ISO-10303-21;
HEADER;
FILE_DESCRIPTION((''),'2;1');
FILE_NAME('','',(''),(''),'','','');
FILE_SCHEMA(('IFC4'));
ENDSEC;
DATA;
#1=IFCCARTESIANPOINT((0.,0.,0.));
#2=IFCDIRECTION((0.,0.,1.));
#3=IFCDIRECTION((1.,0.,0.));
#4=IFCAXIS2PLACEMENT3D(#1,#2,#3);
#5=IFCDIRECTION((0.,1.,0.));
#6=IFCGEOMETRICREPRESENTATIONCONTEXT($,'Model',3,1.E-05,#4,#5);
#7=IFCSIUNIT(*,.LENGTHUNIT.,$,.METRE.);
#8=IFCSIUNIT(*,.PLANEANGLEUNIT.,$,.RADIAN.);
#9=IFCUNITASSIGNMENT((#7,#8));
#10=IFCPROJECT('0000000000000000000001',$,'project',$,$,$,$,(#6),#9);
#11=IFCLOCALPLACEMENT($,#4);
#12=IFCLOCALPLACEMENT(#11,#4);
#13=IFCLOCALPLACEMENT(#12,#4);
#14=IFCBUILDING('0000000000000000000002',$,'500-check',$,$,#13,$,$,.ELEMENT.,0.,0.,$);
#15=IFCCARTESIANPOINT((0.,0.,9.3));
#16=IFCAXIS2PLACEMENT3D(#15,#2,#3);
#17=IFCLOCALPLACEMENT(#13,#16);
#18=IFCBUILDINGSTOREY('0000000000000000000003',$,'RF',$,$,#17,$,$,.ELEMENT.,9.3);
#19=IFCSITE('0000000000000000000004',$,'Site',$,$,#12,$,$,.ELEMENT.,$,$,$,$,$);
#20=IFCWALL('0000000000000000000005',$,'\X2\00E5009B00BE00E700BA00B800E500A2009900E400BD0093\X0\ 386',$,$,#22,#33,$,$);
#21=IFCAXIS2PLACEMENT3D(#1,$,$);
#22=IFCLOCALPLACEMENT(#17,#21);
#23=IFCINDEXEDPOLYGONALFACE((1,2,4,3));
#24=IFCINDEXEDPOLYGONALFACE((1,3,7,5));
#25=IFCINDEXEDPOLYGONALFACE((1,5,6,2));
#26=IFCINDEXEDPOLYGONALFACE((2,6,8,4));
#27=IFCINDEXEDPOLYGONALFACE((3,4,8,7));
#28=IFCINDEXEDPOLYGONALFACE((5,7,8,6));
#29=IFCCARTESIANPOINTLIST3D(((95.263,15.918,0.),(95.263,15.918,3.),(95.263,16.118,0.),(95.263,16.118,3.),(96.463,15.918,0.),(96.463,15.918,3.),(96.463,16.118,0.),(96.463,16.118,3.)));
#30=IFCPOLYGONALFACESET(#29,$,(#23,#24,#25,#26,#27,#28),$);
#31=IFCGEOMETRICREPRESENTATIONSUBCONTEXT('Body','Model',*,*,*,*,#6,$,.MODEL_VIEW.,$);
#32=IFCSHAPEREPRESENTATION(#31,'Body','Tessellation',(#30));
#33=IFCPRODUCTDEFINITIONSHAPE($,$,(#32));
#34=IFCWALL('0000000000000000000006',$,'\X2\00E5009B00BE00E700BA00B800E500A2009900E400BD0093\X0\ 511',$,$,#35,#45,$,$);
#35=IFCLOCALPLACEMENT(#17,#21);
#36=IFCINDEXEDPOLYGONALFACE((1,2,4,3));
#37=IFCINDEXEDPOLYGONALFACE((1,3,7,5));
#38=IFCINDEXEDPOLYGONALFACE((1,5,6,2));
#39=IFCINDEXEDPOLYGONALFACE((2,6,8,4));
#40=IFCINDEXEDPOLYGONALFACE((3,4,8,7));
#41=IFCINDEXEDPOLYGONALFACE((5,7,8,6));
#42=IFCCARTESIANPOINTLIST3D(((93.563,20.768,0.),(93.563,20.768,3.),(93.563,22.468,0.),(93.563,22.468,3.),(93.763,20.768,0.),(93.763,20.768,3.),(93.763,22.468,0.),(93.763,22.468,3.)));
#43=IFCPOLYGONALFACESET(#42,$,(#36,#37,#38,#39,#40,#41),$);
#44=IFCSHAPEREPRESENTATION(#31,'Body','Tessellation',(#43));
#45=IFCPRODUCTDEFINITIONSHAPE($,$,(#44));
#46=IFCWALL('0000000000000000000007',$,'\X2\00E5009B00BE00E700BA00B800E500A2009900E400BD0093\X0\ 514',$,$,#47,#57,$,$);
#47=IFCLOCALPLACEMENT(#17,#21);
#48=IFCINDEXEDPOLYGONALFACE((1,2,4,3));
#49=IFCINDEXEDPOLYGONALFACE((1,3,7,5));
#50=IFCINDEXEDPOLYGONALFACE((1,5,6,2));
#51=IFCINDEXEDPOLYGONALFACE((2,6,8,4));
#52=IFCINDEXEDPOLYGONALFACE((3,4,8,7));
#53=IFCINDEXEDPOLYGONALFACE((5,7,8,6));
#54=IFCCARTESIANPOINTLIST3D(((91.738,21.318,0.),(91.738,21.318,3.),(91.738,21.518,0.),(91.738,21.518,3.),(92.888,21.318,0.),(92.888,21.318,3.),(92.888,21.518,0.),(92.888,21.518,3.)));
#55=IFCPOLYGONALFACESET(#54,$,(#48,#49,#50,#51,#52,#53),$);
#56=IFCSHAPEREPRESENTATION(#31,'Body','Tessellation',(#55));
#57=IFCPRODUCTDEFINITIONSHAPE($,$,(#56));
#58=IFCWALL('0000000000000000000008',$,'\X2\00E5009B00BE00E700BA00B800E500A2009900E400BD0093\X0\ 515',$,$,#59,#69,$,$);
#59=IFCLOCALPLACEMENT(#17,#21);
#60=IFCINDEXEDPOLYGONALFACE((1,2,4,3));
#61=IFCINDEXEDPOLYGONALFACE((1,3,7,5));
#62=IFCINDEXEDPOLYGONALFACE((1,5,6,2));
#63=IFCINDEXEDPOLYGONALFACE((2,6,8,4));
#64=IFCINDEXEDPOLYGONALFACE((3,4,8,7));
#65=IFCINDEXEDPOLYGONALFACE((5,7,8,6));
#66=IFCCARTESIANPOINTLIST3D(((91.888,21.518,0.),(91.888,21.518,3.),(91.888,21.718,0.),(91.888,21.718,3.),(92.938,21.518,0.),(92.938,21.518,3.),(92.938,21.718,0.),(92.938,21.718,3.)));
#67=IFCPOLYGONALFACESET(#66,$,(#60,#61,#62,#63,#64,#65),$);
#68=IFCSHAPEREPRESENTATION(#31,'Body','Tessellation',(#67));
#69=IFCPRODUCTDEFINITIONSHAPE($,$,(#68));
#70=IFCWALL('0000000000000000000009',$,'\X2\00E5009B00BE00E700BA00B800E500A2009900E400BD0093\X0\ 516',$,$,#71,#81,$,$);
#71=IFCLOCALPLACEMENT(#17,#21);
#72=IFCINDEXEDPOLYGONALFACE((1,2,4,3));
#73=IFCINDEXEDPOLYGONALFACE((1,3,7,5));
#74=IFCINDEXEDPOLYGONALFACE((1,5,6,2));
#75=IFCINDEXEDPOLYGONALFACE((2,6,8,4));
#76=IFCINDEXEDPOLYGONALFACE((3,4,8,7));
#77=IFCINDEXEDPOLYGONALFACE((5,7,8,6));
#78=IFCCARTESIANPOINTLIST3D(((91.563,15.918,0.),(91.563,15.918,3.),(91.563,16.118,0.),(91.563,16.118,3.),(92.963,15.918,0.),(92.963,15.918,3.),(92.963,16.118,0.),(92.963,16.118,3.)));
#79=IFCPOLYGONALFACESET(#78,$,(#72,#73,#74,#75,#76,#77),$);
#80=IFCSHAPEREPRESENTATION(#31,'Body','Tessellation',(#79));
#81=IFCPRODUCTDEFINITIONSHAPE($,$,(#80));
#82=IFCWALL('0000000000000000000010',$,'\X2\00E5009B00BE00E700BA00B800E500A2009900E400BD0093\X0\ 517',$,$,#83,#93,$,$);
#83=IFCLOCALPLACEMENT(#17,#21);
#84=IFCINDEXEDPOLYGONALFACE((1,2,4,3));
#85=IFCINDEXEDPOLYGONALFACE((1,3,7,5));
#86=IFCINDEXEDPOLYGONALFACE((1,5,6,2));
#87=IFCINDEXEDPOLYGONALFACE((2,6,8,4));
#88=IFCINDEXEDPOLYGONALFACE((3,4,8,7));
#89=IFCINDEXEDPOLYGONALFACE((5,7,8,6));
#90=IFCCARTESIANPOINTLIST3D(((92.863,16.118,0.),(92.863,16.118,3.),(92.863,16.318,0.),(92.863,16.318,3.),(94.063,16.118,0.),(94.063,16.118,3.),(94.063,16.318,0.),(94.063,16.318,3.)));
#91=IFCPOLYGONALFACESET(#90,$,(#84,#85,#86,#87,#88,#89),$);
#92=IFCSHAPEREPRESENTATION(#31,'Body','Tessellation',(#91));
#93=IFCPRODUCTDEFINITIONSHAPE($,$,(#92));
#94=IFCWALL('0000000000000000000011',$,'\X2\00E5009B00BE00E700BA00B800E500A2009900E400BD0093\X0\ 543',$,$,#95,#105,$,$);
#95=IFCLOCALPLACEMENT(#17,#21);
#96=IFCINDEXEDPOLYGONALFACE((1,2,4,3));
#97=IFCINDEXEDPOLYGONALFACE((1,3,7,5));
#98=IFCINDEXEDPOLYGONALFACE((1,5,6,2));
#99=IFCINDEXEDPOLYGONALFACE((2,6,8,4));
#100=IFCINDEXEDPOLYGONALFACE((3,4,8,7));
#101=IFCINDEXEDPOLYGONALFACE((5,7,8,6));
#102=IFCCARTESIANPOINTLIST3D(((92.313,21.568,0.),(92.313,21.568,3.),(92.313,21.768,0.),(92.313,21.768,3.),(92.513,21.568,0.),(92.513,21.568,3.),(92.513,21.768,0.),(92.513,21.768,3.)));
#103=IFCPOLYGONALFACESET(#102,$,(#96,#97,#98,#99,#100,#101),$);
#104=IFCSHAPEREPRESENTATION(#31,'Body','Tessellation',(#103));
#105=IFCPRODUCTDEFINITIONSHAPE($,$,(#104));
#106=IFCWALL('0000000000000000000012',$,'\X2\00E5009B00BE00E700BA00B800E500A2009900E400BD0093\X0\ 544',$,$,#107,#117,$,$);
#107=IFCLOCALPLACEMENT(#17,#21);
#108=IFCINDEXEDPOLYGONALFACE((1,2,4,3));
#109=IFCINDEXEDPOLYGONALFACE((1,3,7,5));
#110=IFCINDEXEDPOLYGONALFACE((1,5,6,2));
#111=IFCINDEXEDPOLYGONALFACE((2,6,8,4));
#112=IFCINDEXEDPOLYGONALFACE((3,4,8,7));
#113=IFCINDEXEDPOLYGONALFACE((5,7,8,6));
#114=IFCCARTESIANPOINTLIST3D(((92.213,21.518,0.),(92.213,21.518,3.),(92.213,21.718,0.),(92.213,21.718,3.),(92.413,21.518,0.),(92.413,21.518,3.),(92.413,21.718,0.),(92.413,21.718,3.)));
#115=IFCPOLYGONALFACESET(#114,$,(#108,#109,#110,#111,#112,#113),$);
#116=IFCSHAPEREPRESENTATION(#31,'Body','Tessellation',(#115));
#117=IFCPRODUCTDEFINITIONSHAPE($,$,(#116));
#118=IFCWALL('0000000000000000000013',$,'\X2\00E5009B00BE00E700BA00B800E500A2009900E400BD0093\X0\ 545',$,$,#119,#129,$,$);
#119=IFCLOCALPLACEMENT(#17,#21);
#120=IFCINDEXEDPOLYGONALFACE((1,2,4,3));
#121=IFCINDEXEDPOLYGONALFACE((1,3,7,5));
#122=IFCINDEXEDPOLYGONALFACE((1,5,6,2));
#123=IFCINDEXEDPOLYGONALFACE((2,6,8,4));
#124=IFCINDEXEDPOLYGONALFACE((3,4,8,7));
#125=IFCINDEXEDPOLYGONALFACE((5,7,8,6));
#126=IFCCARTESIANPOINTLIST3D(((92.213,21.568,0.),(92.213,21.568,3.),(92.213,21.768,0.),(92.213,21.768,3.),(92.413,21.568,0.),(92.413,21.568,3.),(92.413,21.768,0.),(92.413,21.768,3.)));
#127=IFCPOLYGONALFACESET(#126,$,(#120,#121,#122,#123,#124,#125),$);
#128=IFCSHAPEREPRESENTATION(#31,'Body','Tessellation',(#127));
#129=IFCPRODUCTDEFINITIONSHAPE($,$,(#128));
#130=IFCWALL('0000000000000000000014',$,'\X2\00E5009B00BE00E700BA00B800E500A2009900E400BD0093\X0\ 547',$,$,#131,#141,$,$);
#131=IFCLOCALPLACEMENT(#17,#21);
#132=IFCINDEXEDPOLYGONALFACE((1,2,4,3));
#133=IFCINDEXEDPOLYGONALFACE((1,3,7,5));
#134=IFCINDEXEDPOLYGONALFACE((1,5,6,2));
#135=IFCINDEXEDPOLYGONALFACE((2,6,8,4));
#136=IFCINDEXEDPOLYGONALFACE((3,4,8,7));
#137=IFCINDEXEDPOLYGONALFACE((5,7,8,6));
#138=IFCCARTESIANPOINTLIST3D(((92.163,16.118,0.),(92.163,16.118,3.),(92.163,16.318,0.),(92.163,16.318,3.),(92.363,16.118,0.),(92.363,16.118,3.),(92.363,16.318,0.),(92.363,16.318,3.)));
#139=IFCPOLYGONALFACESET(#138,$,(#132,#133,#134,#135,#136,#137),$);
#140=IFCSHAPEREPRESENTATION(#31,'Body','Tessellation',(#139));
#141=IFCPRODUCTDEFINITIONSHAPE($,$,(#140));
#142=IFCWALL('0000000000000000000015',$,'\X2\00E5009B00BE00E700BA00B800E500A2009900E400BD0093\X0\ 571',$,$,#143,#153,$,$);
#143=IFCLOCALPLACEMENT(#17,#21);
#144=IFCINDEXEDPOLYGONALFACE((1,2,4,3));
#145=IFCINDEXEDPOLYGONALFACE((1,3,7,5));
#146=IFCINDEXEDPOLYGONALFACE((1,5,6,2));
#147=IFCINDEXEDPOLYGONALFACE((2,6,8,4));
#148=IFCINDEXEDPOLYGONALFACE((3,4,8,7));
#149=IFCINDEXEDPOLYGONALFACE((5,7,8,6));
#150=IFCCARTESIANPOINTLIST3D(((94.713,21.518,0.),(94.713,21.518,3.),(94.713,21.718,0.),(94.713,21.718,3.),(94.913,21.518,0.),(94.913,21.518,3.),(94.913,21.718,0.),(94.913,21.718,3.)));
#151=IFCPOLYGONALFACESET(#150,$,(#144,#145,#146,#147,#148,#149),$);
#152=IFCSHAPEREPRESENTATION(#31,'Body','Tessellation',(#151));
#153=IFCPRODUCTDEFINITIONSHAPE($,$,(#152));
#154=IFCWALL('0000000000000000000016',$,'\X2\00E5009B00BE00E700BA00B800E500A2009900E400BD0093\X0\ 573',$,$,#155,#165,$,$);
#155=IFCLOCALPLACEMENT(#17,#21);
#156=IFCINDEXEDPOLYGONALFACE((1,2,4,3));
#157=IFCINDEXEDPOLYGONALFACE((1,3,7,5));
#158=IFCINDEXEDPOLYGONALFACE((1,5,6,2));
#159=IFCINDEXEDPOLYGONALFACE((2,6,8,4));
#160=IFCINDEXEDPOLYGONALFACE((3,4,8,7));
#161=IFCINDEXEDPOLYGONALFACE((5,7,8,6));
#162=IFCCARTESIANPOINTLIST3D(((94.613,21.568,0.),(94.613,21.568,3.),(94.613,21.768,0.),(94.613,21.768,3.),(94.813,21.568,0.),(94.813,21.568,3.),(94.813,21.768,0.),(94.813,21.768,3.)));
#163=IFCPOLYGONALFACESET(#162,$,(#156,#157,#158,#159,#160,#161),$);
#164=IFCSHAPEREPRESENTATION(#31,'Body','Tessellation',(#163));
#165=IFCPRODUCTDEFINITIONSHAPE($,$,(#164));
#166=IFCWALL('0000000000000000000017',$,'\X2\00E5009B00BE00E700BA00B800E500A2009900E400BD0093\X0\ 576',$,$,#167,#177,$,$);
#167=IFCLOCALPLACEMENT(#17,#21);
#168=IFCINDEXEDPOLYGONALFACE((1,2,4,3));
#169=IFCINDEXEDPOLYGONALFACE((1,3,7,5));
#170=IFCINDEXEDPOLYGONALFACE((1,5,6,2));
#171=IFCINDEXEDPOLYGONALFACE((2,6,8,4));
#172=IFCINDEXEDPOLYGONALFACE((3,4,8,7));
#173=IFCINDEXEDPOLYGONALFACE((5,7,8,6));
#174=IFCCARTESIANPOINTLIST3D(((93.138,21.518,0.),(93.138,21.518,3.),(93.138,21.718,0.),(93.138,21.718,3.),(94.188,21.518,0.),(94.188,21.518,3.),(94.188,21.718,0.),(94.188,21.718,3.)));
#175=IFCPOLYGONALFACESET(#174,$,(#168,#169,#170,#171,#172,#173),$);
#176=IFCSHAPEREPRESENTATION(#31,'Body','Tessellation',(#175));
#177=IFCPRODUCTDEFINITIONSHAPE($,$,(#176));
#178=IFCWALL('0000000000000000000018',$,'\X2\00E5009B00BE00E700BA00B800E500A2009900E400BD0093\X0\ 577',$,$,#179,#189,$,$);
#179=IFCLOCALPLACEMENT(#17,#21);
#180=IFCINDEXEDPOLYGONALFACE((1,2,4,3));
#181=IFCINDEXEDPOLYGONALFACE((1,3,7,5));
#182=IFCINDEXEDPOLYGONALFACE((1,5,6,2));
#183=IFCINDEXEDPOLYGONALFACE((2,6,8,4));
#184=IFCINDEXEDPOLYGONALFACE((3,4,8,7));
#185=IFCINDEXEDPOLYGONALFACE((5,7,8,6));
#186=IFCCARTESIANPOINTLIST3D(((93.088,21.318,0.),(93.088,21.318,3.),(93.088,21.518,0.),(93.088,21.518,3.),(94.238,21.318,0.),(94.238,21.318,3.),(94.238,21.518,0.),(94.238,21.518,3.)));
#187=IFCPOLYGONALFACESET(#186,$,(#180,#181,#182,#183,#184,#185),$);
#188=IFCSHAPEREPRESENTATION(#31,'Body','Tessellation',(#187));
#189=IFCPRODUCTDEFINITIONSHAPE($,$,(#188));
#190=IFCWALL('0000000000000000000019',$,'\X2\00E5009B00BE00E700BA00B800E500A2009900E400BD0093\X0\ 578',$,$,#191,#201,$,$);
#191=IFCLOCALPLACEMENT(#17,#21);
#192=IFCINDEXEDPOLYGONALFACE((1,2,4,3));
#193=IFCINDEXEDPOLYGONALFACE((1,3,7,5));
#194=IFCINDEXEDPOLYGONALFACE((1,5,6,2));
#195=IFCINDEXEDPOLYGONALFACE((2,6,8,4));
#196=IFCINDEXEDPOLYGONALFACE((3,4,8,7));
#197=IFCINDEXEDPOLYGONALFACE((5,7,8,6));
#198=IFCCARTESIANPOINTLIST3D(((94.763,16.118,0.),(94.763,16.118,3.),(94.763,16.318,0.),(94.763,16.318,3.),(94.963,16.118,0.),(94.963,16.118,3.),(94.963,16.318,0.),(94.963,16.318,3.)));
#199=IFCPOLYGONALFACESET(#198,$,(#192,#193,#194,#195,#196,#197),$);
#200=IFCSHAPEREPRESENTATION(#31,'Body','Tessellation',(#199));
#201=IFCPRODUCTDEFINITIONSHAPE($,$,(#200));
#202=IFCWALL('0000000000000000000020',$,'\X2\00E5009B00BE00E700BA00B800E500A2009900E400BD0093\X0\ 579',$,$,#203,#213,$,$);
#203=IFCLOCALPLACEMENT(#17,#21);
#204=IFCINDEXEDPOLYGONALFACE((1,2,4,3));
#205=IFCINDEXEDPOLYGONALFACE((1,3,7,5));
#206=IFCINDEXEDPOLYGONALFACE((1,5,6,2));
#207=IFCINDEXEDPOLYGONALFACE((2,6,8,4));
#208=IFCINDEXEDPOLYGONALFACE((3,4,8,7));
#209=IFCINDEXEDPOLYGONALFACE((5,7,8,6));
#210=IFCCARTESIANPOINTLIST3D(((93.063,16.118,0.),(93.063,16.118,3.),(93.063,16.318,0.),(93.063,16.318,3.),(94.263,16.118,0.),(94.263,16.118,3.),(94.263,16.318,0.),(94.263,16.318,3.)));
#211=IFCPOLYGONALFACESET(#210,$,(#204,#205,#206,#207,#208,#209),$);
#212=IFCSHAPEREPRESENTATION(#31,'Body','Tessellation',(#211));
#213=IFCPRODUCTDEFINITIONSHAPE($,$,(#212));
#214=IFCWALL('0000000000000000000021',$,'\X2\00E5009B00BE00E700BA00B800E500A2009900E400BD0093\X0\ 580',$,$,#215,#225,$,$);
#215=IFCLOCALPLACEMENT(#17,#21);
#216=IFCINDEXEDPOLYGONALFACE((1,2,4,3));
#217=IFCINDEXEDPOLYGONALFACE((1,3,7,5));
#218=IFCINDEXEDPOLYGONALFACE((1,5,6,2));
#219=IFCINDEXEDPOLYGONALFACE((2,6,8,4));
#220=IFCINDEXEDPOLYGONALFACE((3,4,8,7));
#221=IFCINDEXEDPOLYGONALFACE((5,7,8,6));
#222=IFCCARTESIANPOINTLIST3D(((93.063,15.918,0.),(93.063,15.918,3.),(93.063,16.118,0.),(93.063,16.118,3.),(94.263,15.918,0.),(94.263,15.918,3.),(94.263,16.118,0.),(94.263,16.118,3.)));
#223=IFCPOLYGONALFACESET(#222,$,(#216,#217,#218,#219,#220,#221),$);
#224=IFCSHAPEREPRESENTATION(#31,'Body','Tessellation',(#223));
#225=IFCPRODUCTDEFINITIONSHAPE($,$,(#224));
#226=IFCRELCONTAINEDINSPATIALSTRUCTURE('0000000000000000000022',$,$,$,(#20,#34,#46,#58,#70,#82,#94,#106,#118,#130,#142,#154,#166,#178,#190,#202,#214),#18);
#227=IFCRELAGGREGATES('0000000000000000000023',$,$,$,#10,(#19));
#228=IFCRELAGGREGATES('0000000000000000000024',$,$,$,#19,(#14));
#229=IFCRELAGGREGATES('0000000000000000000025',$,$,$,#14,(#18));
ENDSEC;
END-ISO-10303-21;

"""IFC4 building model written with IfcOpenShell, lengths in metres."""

from ifc_helpers import new_model, si_unit, direction, frame, frame_2d, origin_with_axes, place, context, subcontext, project, spatial, rectangle, extrude, element, save


model = new_model("IFC4")

# Units and contexts
model_context = context("Model", 3, precision=1e-05, world=origin_with_axes(), true_north=direction((0.0, 1.0, 0.0)))
body_context = subcontext(model_context, "Body", "Model", "MODEL_VIEW")
ifc_project = project(units=[si_unit("LENGTHUNIT", "METRE"), si_unit("PLANEANGLEUNIT", "RADIAN")], contexts=[model_context])

# Site, building, storey
placement = place(None, origin_with_axes())
site_placement = place(placement, origin_with_axes())
site = spatial("IfcSite", under=ifc_project, at=site_placement, Name="Site", CompositionType="ELEMENT")
building_placement = place(site_placement, origin_with_axes())
building = spatial("IfcBuilding", under=site, at=building_placement, Name="500-check", CompositionType="ELEMENT", ElevationOfRefHeight=0.0, ElevationOfTerrain=0.0)
storey_placement = place(building_placement, frame((0.0, 0.0, 9.3), z_axis=(0.0, 0.0, 1.0), x_axis=(1.0, 0.0, 0.0)))
storey = spatial("IfcBuildingStorey", under=building, at=storey_placement, Name="RF", CompositionType="ELEMENT", Elevation=9.3)

# Walls
wall_1_placement = place(storey_placement, frame((95.863, 16.018, 0.0), z_axis=(0.0, 0.0, 1.0), x_axis=(1.0, 0.0, 0.0)))
element("IfcWall", 1, at=wall_1_placement, inside=storey, Name="å\u009b¾çº¸å¢\u0099ä½\u0093 386", context=body_context, shape_type="SweptSolid", body=[
    extrude(rectangle(XDim=1.2, YDim=0.2, at=frame_2d((0.0, 0.0), x_axis=(1.0, 0.0, 0.0))), frame((0.0, 0.0, 0.0), z_axis=(0.0, 0.0, 1.0)), (0.0, 0.0, 1.0), 3.0),
])
wall_2_placement = place(storey_placement, frame((93.663, 21.618, 0.0), z_axis=(0.0, 0.0, 1.0), x_axis=(0.0, 1.0, 0.0)))
element("IfcWall", 2, at=wall_2_placement, inside=storey, Name="å\u009b¾çº¸å¢\u0099ä½\u0093 511", context=body_context, shape_type="SweptSolid", body=[
    extrude(rectangle(XDim=1.7, YDim=0.2, at=frame_2d((0.0, 0.0), x_axis=(1.0, 0.0, 0.0))), frame((0.0, 0.0, 0.0), z_axis=(0.0, 0.0, 1.0)), (0.0, 0.0, 1.0), 3.0),
])
wall_3_placement = place(storey_placement, frame((92.313, 21.418, 0.0), z_axis=(0.0, 0.0, 1.0), x_axis=(1.0, 0.0, 0.0)))
element("IfcWall", 3, at=wall_3_placement, inside=storey, Name="å\u009b¾çº¸å¢\u0099ä½\u0093 514", context=body_context, shape_type="SweptSolid", body=[
    extrude(rectangle(XDim=1.15, YDim=0.2, at=frame_2d((0.0, 0.0), x_axis=(1.0, 0.0, 0.0))), frame((0.0, 0.0, 0.0), z_axis=(0.0, 0.0, 1.0)), (0.0, 0.0, 1.0), 3.0),
])
wall_4_placement = place(storey_placement, frame((92.413, 21.618, 0.0), z_axis=(0.0, 0.0, 1.0), x_axis=(1.0, 0.0, 0.0)))
element("IfcWall", 4, at=wall_4_placement, inside=storey, Name="å\u009b¾çº¸å¢\u0099ä½\u0093 515", context=body_context, shape_type="SweptSolid", body=[
    extrude(rectangle(XDim=1.05, YDim=0.2, at=frame_2d((0.0, 0.0), x_axis=(1.0, 0.0, 0.0))), frame((0.0, 0.0, 0.0), z_axis=(0.0, 0.0, 1.0)), (0.0, 0.0, 1.0), 3.0),
])
wall_5_placement = place(storey_placement, frame((92.263, 16.018, 0.0), z_axis=(0.0, 0.0, 1.0), x_axis=(1.0, 0.0, 0.0)))
element("IfcWall", 5, at=wall_5_placement, inside=storey, Name="å\u009b¾çº¸å¢\u0099ä½\u0093 516", context=body_context, shape_type="SweptSolid", body=[
    extrude(rectangle(XDim=1.4, YDim=0.2, at=frame_2d((0.0, 0.0), x_axis=(1.0, 0.0, 0.0))), frame((0.0, 0.0, 0.0), z_axis=(0.0, 0.0, 1.0)), (0.0, 0.0, 1.0), 3.0),
])
wall_6_placement = place(storey_placement, frame((93.463, 16.218, 0.0), z_axis=(0.0, 0.0, 1.0), x_axis=(-1.0, 0.0, 0.0)))
element("IfcWall", 6, at=wall_6_placement, inside=storey, Name="å\u009b¾çº¸å¢\u0099ä½\u0093 517", context=body_context, shape_type="SweptSolid", body=[
    extrude(rectangle(XDim=1.2, YDim=0.2, at=frame_2d((0.0, 0.0), x_axis=(1.0, 0.0, 0.0))), frame((0.0, 0.0, 0.0), z_axis=(0.0, 0.0, 1.0)), (0.0, 0.0, 1.0), 3.0),
])
for number, where, z_axis, x_axis, name in (
    (7, (92.413, 21.668, 0.0), (0.0, 0.0, 1.0), (-1.0, 0.0, 0.0), "å\u009b¾çº¸å¢\u0099ä½\u0093 543"),
    (8, (92.313, 21.618, 0.0), (0.0, 0.0, 1.0), (0.0, -1.0, 0.0), "å\u009b¾çº¸å¢\u0099ä½\u0093 544"),
    (9, (92.313, 21.668, 0.0), (0.0, 0.0, 1.0), (0.0, -1.0, 0.0), "å\u009b¾çº¸å¢\u0099ä½\u0093 545"),
    (10, (92.263, 16.218, 0.0), (0.0, 0.0, 1.0), (0.0, -1.0, 0.0), "å\u009b¾çº¸å¢\u0099ä½\u0093 547"),
    (11, (94.813, 21.618, 0.0), (0.0, 0.0, 1.0), (0.0, -1.0, 0.0), "å\u009b¾çº¸å¢\u0099ä½\u0093 571"),
    (12, (94.713, 21.668, 0.0), (0.0, 0.0, 1.0), (1.0, 0.0, 0.0), "å\u009b¾çº¸å¢\u0099ä½\u0093 573"),
):
    element("IfcWall", number, at=place(storey_placement, frame(where, z_axis=z_axis, x_axis=x_axis)), inside=storey, Name=name, context=body_context, shape_type="SweptSolid", body=[
        extrude(rectangle(XDim=0.2, YDim=0.2, at=frame_2d((0.0, 0.0), x_axis=(1.0, 0.0, 0.0))), frame((0.0, 0.0, 0.0), z_axis=(0.0, 0.0, 1.0)), (0.0, 0.0, 1.0), 3.0),
    ])
wall_7_placement = place(storey_placement, frame((93.663, 21.618, 0.0), z_axis=(0.0, 0.0, 1.0), x_axis=(1.0, 0.0, 0.0)))
element("IfcWall", 13, at=wall_7_placement, inside=storey, Name="å\u009b¾çº¸å¢\u0099ä½\u0093 576", context=body_context, shape_type="SweptSolid", body=[
    extrude(rectangle(XDim=1.05, YDim=0.2, at=frame_2d((0.0, 0.0), x_axis=(1.0, 0.0, 0.0))), frame((0.0, 0.0, 0.0), z_axis=(0.0, 0.0, 1.0)), (0.0, 0.0, 1.0), 3.0),
])
wall_8_placement = place(storey_placement, frame((93.663, 21.418, 0.0), z_axis=(0.0, 0.0, 1.0), x_axis=(1.0, 0.0, 0.0)))
element("IfcWall", 14, at=wall_8_placement, inside=storey, Name="å\u009b¾çº¸å¢\u0099ä½\u0093 577", context=body_context, shape_type="SweptSolid", body=[
    extrude(rectangle(XDim=1.15, YDim=0.2, at=frame_2d((0.0, 0.0), x_axis=(1.0, 0.0, 0.0))), frame((0.0, 0.0, 0.0), z_axis=(0.0, 0.0, 1.0)), (0.0, 0.0, 1.0), 3.0),
])
wall_9_placement = place(storey_placement, frame((94.863, 16.218, 0.0), z_axis=(0.0, 0.0, 1.0), x_axis=(0.0, -1.0, 0.0)))
element("IfcWall", 15, at=wall_9_placement, inside=storey, Name="å\u009b¾çº¸å¢\u0099ä½\u0093 578", context=body_context, shape_type="SweptSolid", body=[
    extrude(rectangle(XDim=0.2, YDim=0.2, at=frame_2d((0.0, 0.0), x_axis=(1.0, 0.0, 0.0))), frame((0.0, 0.0, 0.0), z_axis=(0.0, 0.0, 1.0)), (0.0, 0.0, 1.0), 3.0),
])
for number, where, z_axis, x_axis, name in (
    (16, (93.663, 16.218, 0.0), (0.0, 0.0, 1.0), (1.0, 0.0, 0.0), "å\u009b¾çº¸å¢\u0099ä½\u0093 579"),
    (17, (93.663, 16.018, 0.0), (0.0, 0.0, 1.0), (1.0, 0.0, 0.0), "å\u009b¾çº¸å¢\u0099ä½\u0093 580"),
):
    element("IfcWall", number, at=place(storey_placement, frame(where, z_axis=z_axis, x_axis=x_axis)), inside=storey, Name=name, context=body_context, shape_type="SweptSolid", body=[
        extrude(rectangle(XDim=1.2, YDim=0.2, at=frame_2d((0.0, 0.0), x_axis=(1.0, 0.0, 0.0))), frame((0.0, 0.0, 0.0), z_axis=(0.0, 0.0, 1.0)), (0.0, 0.0, 1.0), 3.0),
    ])

save(model, "model.ifc")
